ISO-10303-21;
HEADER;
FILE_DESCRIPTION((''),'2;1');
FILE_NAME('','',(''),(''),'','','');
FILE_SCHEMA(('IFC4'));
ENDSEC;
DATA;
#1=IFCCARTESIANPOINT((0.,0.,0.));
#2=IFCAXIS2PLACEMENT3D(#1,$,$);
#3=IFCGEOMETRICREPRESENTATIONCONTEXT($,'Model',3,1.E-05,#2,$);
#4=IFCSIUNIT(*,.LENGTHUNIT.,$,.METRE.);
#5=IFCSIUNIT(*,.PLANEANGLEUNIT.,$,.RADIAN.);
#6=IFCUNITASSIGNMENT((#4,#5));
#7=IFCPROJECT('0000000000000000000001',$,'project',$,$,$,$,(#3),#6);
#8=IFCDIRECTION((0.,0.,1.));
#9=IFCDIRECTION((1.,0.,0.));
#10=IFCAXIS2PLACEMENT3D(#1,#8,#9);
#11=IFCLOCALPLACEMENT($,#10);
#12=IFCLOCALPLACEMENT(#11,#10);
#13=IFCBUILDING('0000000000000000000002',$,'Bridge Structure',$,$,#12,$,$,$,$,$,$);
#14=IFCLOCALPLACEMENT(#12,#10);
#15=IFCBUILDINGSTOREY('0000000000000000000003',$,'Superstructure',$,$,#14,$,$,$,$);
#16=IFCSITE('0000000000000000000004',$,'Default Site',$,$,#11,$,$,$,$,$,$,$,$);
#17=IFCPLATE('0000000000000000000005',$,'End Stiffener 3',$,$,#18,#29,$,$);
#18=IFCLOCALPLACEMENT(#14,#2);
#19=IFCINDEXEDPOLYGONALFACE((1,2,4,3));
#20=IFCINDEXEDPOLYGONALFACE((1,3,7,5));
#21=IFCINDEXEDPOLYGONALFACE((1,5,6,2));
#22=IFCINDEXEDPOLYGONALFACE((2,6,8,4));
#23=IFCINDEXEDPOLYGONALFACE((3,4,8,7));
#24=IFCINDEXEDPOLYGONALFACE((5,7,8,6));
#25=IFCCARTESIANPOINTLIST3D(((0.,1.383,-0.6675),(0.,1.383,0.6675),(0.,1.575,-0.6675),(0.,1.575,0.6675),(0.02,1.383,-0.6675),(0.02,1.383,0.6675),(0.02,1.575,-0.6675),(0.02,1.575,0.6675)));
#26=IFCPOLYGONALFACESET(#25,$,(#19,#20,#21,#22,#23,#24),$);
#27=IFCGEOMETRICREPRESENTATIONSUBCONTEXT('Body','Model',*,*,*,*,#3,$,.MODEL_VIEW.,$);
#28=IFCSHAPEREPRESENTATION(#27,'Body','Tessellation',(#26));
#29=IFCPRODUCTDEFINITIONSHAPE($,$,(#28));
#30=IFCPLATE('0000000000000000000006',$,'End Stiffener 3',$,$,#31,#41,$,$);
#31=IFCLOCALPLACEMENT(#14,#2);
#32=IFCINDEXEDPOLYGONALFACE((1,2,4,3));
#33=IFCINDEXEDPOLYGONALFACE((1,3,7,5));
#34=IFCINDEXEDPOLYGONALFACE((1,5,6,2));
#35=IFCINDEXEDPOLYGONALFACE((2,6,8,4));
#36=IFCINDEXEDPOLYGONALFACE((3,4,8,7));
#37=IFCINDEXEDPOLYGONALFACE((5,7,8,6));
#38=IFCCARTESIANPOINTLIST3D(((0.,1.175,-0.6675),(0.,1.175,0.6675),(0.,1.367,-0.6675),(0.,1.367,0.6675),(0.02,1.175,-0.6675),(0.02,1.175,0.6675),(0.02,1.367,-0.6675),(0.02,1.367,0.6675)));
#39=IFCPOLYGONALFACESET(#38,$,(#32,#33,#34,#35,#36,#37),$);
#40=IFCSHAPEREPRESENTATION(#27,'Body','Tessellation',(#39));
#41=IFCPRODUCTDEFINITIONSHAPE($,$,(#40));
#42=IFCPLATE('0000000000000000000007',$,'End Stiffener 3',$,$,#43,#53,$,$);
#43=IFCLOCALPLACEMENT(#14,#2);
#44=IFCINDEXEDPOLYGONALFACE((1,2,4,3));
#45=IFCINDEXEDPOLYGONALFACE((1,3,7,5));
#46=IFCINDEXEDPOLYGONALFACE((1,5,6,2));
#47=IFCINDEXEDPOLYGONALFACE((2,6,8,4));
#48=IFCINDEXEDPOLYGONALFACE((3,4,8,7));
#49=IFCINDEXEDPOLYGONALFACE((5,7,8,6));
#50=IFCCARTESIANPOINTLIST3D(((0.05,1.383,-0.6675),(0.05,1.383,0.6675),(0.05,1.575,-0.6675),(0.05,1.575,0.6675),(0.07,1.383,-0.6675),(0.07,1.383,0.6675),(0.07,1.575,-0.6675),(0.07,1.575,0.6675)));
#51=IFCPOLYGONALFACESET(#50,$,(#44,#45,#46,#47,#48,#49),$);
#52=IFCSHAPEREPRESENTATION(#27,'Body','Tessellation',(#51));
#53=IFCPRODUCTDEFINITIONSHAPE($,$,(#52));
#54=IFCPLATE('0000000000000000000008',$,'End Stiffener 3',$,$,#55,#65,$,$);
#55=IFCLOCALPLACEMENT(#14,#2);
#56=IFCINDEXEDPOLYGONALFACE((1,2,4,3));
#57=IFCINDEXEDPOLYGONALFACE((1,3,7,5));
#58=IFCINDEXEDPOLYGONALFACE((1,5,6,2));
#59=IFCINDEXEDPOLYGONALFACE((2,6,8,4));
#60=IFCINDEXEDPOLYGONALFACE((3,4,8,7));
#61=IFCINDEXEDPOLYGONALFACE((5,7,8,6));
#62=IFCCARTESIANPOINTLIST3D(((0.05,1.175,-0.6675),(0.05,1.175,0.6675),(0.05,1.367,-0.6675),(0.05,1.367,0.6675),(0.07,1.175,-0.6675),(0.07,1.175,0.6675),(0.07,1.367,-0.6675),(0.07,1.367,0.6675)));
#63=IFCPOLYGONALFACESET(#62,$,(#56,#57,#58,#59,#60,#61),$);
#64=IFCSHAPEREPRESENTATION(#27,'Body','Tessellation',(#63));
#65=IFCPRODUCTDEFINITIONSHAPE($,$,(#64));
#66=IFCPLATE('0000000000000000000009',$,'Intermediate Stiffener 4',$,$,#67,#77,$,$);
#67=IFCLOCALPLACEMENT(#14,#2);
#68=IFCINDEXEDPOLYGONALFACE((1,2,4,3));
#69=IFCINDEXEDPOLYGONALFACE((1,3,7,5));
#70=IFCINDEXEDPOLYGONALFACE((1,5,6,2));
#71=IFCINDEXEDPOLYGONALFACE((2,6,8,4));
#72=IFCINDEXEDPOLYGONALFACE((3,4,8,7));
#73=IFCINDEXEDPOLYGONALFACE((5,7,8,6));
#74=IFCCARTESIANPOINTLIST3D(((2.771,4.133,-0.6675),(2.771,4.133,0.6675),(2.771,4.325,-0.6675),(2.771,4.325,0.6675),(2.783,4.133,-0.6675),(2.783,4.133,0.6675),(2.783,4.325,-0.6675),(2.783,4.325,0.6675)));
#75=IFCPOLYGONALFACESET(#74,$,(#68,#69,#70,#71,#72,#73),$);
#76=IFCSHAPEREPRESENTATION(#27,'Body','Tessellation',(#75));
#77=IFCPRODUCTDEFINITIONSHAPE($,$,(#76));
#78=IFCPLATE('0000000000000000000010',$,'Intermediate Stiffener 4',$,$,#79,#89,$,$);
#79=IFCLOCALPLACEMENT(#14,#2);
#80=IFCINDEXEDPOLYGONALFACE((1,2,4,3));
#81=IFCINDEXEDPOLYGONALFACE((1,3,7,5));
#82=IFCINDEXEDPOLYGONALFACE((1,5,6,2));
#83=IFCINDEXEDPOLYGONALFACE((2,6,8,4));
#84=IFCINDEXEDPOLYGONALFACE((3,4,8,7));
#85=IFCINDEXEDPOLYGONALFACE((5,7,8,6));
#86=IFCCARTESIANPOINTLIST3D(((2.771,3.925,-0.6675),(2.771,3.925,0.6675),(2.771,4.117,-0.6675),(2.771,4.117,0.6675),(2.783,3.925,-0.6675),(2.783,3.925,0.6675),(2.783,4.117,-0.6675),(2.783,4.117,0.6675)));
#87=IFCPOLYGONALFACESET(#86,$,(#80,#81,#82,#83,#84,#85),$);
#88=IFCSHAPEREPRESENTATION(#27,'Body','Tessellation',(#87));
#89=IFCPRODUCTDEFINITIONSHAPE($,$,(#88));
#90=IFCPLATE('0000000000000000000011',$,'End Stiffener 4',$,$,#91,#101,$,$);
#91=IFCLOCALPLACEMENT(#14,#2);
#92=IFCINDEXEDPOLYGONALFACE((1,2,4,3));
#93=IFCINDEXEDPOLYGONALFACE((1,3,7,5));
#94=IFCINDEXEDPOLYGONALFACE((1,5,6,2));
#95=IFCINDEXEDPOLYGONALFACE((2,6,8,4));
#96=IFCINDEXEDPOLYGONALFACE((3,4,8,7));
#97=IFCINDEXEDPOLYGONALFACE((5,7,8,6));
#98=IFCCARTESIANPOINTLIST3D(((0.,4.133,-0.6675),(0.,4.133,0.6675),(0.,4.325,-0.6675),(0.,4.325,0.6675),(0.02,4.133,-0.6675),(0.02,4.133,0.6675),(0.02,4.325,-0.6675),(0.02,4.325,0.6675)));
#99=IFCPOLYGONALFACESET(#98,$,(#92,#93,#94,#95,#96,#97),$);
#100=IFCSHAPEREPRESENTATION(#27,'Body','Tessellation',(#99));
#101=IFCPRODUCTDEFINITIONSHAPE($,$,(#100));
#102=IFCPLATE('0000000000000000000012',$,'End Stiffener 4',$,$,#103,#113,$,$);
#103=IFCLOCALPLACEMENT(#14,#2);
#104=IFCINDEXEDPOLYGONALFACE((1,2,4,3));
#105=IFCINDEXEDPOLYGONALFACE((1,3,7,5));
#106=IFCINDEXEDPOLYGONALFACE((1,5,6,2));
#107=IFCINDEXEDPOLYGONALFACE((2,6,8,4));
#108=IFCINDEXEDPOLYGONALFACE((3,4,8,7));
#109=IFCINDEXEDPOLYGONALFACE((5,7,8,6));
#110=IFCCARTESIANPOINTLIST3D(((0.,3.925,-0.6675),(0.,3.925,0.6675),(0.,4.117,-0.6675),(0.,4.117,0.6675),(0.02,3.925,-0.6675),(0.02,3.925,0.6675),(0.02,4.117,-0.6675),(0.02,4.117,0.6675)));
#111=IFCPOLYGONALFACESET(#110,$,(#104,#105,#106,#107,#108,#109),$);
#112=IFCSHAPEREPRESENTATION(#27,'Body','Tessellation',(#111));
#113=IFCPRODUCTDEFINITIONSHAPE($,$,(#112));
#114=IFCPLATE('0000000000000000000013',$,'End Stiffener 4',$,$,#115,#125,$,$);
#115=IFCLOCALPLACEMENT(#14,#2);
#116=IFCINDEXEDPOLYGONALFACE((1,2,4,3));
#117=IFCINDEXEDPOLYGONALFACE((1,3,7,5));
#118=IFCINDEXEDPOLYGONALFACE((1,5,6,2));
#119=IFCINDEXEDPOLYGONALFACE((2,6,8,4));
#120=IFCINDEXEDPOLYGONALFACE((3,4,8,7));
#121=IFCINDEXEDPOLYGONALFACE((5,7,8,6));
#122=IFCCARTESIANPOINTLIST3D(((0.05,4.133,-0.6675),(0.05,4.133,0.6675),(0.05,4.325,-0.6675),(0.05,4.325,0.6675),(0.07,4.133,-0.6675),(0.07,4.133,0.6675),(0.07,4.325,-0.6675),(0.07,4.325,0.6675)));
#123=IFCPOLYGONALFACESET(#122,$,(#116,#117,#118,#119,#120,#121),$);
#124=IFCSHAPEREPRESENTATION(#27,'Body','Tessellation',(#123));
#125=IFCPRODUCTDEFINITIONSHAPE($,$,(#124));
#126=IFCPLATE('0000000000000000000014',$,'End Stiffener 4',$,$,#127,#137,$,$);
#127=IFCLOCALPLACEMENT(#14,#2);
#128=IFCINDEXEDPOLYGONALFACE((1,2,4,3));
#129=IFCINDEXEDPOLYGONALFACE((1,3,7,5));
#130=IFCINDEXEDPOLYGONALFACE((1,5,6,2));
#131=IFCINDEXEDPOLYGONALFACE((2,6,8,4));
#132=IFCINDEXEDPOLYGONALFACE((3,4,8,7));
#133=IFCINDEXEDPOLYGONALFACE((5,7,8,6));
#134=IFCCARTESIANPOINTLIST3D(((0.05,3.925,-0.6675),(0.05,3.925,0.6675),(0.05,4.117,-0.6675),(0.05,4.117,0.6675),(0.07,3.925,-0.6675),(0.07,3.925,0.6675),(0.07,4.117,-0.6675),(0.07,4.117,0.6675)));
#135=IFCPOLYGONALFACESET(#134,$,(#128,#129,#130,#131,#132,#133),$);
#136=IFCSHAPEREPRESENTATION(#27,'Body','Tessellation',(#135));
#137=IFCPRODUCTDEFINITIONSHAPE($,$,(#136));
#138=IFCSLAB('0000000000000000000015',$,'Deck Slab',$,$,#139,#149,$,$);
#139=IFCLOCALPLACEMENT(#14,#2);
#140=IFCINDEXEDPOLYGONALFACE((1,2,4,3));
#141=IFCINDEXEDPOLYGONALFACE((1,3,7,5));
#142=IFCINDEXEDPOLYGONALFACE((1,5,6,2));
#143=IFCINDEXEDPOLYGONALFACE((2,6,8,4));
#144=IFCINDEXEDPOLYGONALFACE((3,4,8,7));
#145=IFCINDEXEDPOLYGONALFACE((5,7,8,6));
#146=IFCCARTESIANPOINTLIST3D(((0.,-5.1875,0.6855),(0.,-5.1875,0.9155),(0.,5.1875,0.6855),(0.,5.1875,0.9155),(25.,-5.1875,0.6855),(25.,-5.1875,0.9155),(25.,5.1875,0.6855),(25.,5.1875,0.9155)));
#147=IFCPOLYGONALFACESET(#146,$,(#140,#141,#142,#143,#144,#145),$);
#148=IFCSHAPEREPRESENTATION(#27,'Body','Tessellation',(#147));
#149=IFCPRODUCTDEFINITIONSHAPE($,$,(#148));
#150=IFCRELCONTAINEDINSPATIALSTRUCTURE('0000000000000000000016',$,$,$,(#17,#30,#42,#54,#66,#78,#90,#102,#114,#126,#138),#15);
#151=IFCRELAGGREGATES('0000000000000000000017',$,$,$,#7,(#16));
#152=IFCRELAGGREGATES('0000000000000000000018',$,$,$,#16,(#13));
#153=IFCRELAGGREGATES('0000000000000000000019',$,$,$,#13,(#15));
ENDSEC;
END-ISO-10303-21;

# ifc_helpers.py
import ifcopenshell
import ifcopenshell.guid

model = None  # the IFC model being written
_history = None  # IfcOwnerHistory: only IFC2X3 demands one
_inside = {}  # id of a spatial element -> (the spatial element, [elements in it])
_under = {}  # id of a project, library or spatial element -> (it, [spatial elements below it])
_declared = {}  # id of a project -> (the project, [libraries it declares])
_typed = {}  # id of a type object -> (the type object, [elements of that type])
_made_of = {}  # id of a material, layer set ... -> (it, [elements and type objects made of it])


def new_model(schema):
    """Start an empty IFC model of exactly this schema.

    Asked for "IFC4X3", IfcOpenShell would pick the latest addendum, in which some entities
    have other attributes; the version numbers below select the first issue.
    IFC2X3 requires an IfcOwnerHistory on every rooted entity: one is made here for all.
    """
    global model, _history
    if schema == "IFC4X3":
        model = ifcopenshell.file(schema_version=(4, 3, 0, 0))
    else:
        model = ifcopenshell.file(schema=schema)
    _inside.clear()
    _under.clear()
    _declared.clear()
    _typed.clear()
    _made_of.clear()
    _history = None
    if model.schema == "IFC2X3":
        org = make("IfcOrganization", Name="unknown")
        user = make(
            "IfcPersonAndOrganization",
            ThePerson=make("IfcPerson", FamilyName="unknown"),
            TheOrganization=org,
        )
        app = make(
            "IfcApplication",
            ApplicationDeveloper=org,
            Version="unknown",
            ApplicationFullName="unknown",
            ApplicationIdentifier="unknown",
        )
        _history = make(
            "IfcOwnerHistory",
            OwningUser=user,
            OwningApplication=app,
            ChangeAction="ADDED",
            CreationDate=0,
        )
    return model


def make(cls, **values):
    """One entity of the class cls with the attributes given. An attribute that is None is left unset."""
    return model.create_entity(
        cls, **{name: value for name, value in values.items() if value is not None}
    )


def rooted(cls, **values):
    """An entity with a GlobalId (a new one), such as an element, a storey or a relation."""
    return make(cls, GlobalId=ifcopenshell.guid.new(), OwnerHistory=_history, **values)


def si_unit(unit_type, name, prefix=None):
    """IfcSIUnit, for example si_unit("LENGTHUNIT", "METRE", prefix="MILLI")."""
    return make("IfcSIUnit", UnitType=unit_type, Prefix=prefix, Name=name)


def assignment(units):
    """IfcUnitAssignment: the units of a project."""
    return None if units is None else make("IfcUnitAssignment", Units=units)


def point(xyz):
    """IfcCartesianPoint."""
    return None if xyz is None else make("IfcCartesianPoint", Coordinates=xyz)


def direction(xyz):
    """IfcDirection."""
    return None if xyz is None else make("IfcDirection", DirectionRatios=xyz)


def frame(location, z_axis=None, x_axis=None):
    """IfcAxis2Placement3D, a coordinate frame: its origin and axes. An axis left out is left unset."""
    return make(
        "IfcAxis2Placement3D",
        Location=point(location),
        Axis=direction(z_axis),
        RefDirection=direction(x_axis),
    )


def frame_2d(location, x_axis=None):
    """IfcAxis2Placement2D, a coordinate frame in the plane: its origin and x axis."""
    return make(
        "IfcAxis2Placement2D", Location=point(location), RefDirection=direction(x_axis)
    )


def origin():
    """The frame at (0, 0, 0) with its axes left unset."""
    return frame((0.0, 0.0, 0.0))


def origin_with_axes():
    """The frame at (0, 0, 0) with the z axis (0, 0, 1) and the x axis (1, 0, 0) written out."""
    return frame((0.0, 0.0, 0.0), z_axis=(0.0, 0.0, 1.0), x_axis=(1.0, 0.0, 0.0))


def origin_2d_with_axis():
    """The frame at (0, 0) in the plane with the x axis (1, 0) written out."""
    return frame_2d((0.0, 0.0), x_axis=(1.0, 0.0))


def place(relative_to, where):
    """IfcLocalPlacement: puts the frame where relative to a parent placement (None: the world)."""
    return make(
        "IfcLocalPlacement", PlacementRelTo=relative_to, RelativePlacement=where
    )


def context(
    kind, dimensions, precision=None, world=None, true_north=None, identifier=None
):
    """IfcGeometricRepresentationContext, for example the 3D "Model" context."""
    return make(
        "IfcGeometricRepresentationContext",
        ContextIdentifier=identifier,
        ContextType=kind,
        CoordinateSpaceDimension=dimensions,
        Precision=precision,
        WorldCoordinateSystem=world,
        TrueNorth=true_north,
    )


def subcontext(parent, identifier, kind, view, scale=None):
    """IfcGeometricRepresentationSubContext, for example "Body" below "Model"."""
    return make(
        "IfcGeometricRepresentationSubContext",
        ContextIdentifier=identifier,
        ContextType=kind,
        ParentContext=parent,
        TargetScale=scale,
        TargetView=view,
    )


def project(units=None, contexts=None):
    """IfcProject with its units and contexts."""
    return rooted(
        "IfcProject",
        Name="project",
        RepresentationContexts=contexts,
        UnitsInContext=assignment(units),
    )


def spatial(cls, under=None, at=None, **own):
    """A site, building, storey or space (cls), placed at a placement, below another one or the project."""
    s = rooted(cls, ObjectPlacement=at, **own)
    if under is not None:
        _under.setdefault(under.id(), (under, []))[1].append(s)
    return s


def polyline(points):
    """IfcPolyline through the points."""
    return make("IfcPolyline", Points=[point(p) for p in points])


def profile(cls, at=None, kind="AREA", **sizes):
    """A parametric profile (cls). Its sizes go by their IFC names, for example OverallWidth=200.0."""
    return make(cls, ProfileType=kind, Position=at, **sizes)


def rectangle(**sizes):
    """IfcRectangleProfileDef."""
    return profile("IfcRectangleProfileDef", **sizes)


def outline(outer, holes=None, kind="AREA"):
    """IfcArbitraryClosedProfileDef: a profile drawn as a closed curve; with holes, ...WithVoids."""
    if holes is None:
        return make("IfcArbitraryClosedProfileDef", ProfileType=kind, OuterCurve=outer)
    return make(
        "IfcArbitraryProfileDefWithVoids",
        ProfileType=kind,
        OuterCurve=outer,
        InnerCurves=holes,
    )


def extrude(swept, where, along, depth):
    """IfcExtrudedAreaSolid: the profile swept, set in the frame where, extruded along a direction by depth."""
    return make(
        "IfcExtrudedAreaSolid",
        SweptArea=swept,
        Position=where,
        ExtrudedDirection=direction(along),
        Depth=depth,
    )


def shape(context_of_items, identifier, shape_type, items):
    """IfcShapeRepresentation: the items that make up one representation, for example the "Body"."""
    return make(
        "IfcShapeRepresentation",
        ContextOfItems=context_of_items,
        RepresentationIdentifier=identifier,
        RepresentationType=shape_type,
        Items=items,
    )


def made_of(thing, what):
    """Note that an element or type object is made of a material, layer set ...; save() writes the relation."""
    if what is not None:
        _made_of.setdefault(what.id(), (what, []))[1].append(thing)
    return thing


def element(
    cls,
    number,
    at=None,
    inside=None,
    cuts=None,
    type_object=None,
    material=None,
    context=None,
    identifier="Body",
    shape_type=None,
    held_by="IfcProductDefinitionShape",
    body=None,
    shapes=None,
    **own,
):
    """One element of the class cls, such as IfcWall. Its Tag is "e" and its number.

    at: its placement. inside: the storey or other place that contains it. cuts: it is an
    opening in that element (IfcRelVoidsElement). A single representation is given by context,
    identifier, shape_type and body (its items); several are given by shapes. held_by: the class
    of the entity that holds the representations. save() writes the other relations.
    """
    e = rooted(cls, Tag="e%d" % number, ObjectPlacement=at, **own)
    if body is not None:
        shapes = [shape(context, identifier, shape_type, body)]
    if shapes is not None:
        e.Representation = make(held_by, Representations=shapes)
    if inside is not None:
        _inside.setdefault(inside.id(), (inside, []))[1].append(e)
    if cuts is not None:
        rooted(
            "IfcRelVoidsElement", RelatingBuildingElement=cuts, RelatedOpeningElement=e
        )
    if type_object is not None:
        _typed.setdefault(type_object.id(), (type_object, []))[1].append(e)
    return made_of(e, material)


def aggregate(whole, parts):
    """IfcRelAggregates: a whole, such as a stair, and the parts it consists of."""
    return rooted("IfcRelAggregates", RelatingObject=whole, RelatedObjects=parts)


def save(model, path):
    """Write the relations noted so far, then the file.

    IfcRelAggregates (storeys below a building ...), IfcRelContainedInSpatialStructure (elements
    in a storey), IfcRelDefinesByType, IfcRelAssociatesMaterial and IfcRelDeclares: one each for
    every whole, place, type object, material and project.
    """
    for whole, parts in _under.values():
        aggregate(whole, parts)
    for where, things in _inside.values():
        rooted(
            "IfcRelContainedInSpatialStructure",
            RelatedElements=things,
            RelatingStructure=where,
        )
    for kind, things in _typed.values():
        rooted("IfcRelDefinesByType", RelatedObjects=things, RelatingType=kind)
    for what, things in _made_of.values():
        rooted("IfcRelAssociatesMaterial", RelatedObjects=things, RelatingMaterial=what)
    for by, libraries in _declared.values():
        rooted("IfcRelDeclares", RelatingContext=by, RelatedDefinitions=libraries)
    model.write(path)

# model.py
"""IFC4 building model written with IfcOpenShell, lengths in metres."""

from ifc_helpers import new_model, si_unit, frame, origin, origin_with_axes, origin_2d_with_axis, place, context, subcontext, project, spatial, polyline, rectangle, outline, extrude, element, save


model = new_model("IFC4")

# Units and contexts
model_context = context("Model", 3, precision=1e-05, world=origin())
body_context = subcontext(model_context, "Body", "Model", "MODEL_VIEW")
ifc_project = project(units=[si_unit("LENGTHUNIT", "METRE"), si_unit("PLANEANGLEUNIT", "RADIAN")], contexts=[model_context])

# Site, building, storey
site_placement = place(None, origin_with_axes())
site = spatial("IfcSite", under=ifc_project, at=site_placement, Name="Default Site")
building_placement = place(site_placement, origin_with_axes())
building = spatial("IfcBuilding", under=site, at=building_placement, Name="Bridge Structure")
storey_placement = place(building_placement, origin_with_axes())
storey = spatial("IfcBuildingStorey", under=building, at=storey_placement, Name="Superstructure")

# Plates
for number, where, z_axis, x_axis, name in (
    (1, (0.01, 1.479, -0.6675), (0.0, 0.0, 1.0), (1.0, 0.0, 0.0), "End Stiffener 3"),
    (2, (0.01, 1.271, -0.6675), (0.0, 0.0, 1.0), (1.0, 0.0, 0.0), "End Stiffener 3"),
    (3, (0.06, 1.479, -0.6675), (0.0, 0.0, 1.0), (1.0, 0.0, 0.0), "End Stiffener 3"),
    (4, (0.06, 1.271, -0.6675), (0.0, 0.0, 1.0), (1.0, 0.0, 0.0), "End Stiffener 3"),
):
    element("IfcPlate", number, at=place(storey_placement, frame(where, z_axis=z_axis, x_axis=x_axis)), inside=storey, Name=name, context=body_context, shape_type="SweptSolid", body=[
        extrude(rectangle(XDim=0.02, YDim=0.192, at=origin_2d_with_axis()), origin_with_axes(), (0.0, 0.0, 1.0), 1.335),
    ])
for number, where, z_axis, x_axis, name in (
    (5, (2.777, 4.229, -0.6675), (0.0, 0.0, 1.0), (1.0, 0.0, 0.0), "Intermediate Stiffener 4"),
    (6, (2.777, 4.021, -0.6675), (0.0, 0.0, 1.0), (1.0, 0.0, 0.0), "Intermediate Stiffener 4"),
):
    element("IfcPlate", number, at=place(storey_placement, frame(where, z_axis=z_axis, x_axis=x_axis)), inside=storey, Name=name, context=body_context, shape_type="SweptSolid", body=[
        extrude(rectangle(XDim=0.012, YDim=0.192, at=origin_2d_with_axis()), origin_with_axes(), (0.0, 0.0, 1.0), 1.335),
    ])
for number, where, z_axis, x_axis, name in (
    (7, (0.01, 4.229, -0.6675), (0.0, 0.0, 1.0), (1.0, 0.0, 0.0), "End Stiffener 4"),
    (8, (0.01, 4.021, -0.6675), (0.0, 0.0, 1.0), (1.0, 0.0, 0.0), "End Stiffener 4"),
    (9, (0.06, 4.229, -0.6675), (0.0, 0.0, 1.0), (1.0, 0.0, 0.0), "End Stiffener 4"),
    (10, (0.06, 4.021, -0.6675), (0.0, 0.0, 1.0), (1.0, 0.0, 0.0), "End Stiffener 4"),
):
    element("IfcPlate", number, at=place(storey_placement, frame(where, z_axis=z_axis, x_axis=x_axis)), inside=storey, Name=name, context=body_context, shape_type="SweptSolid", body=[
        extrude(rectangle(XDim=0.02, YDim=0.192, at=origin_2d_with_axis()), origin_with_axes(), (0.0, 0.0, 1.0), 1.335),
    ])

# Slab
slab_placement = place(storey_placement, frame((0.0, 0.0, 0.6855), z_axis=(0.0, 0.0, 1.0), x_axis=(1.0, 0.0, 0.0)))
element("IfcSlab", 11, at=slab_placement, inside=storey, Name="Deck Slab", context=body_context, shape_type="SweptSolid", body=[
    extrude(outline(polyline([(0.0, -5.1875), (25.0, -5.1875), (25.0, 5.1875), (0.0, 5.1875), (0.0, -5.1875)])), origin_with_axes(), (0.0, 0.0, 1.0), 0.23),
])

save(model, "model.ifc")
